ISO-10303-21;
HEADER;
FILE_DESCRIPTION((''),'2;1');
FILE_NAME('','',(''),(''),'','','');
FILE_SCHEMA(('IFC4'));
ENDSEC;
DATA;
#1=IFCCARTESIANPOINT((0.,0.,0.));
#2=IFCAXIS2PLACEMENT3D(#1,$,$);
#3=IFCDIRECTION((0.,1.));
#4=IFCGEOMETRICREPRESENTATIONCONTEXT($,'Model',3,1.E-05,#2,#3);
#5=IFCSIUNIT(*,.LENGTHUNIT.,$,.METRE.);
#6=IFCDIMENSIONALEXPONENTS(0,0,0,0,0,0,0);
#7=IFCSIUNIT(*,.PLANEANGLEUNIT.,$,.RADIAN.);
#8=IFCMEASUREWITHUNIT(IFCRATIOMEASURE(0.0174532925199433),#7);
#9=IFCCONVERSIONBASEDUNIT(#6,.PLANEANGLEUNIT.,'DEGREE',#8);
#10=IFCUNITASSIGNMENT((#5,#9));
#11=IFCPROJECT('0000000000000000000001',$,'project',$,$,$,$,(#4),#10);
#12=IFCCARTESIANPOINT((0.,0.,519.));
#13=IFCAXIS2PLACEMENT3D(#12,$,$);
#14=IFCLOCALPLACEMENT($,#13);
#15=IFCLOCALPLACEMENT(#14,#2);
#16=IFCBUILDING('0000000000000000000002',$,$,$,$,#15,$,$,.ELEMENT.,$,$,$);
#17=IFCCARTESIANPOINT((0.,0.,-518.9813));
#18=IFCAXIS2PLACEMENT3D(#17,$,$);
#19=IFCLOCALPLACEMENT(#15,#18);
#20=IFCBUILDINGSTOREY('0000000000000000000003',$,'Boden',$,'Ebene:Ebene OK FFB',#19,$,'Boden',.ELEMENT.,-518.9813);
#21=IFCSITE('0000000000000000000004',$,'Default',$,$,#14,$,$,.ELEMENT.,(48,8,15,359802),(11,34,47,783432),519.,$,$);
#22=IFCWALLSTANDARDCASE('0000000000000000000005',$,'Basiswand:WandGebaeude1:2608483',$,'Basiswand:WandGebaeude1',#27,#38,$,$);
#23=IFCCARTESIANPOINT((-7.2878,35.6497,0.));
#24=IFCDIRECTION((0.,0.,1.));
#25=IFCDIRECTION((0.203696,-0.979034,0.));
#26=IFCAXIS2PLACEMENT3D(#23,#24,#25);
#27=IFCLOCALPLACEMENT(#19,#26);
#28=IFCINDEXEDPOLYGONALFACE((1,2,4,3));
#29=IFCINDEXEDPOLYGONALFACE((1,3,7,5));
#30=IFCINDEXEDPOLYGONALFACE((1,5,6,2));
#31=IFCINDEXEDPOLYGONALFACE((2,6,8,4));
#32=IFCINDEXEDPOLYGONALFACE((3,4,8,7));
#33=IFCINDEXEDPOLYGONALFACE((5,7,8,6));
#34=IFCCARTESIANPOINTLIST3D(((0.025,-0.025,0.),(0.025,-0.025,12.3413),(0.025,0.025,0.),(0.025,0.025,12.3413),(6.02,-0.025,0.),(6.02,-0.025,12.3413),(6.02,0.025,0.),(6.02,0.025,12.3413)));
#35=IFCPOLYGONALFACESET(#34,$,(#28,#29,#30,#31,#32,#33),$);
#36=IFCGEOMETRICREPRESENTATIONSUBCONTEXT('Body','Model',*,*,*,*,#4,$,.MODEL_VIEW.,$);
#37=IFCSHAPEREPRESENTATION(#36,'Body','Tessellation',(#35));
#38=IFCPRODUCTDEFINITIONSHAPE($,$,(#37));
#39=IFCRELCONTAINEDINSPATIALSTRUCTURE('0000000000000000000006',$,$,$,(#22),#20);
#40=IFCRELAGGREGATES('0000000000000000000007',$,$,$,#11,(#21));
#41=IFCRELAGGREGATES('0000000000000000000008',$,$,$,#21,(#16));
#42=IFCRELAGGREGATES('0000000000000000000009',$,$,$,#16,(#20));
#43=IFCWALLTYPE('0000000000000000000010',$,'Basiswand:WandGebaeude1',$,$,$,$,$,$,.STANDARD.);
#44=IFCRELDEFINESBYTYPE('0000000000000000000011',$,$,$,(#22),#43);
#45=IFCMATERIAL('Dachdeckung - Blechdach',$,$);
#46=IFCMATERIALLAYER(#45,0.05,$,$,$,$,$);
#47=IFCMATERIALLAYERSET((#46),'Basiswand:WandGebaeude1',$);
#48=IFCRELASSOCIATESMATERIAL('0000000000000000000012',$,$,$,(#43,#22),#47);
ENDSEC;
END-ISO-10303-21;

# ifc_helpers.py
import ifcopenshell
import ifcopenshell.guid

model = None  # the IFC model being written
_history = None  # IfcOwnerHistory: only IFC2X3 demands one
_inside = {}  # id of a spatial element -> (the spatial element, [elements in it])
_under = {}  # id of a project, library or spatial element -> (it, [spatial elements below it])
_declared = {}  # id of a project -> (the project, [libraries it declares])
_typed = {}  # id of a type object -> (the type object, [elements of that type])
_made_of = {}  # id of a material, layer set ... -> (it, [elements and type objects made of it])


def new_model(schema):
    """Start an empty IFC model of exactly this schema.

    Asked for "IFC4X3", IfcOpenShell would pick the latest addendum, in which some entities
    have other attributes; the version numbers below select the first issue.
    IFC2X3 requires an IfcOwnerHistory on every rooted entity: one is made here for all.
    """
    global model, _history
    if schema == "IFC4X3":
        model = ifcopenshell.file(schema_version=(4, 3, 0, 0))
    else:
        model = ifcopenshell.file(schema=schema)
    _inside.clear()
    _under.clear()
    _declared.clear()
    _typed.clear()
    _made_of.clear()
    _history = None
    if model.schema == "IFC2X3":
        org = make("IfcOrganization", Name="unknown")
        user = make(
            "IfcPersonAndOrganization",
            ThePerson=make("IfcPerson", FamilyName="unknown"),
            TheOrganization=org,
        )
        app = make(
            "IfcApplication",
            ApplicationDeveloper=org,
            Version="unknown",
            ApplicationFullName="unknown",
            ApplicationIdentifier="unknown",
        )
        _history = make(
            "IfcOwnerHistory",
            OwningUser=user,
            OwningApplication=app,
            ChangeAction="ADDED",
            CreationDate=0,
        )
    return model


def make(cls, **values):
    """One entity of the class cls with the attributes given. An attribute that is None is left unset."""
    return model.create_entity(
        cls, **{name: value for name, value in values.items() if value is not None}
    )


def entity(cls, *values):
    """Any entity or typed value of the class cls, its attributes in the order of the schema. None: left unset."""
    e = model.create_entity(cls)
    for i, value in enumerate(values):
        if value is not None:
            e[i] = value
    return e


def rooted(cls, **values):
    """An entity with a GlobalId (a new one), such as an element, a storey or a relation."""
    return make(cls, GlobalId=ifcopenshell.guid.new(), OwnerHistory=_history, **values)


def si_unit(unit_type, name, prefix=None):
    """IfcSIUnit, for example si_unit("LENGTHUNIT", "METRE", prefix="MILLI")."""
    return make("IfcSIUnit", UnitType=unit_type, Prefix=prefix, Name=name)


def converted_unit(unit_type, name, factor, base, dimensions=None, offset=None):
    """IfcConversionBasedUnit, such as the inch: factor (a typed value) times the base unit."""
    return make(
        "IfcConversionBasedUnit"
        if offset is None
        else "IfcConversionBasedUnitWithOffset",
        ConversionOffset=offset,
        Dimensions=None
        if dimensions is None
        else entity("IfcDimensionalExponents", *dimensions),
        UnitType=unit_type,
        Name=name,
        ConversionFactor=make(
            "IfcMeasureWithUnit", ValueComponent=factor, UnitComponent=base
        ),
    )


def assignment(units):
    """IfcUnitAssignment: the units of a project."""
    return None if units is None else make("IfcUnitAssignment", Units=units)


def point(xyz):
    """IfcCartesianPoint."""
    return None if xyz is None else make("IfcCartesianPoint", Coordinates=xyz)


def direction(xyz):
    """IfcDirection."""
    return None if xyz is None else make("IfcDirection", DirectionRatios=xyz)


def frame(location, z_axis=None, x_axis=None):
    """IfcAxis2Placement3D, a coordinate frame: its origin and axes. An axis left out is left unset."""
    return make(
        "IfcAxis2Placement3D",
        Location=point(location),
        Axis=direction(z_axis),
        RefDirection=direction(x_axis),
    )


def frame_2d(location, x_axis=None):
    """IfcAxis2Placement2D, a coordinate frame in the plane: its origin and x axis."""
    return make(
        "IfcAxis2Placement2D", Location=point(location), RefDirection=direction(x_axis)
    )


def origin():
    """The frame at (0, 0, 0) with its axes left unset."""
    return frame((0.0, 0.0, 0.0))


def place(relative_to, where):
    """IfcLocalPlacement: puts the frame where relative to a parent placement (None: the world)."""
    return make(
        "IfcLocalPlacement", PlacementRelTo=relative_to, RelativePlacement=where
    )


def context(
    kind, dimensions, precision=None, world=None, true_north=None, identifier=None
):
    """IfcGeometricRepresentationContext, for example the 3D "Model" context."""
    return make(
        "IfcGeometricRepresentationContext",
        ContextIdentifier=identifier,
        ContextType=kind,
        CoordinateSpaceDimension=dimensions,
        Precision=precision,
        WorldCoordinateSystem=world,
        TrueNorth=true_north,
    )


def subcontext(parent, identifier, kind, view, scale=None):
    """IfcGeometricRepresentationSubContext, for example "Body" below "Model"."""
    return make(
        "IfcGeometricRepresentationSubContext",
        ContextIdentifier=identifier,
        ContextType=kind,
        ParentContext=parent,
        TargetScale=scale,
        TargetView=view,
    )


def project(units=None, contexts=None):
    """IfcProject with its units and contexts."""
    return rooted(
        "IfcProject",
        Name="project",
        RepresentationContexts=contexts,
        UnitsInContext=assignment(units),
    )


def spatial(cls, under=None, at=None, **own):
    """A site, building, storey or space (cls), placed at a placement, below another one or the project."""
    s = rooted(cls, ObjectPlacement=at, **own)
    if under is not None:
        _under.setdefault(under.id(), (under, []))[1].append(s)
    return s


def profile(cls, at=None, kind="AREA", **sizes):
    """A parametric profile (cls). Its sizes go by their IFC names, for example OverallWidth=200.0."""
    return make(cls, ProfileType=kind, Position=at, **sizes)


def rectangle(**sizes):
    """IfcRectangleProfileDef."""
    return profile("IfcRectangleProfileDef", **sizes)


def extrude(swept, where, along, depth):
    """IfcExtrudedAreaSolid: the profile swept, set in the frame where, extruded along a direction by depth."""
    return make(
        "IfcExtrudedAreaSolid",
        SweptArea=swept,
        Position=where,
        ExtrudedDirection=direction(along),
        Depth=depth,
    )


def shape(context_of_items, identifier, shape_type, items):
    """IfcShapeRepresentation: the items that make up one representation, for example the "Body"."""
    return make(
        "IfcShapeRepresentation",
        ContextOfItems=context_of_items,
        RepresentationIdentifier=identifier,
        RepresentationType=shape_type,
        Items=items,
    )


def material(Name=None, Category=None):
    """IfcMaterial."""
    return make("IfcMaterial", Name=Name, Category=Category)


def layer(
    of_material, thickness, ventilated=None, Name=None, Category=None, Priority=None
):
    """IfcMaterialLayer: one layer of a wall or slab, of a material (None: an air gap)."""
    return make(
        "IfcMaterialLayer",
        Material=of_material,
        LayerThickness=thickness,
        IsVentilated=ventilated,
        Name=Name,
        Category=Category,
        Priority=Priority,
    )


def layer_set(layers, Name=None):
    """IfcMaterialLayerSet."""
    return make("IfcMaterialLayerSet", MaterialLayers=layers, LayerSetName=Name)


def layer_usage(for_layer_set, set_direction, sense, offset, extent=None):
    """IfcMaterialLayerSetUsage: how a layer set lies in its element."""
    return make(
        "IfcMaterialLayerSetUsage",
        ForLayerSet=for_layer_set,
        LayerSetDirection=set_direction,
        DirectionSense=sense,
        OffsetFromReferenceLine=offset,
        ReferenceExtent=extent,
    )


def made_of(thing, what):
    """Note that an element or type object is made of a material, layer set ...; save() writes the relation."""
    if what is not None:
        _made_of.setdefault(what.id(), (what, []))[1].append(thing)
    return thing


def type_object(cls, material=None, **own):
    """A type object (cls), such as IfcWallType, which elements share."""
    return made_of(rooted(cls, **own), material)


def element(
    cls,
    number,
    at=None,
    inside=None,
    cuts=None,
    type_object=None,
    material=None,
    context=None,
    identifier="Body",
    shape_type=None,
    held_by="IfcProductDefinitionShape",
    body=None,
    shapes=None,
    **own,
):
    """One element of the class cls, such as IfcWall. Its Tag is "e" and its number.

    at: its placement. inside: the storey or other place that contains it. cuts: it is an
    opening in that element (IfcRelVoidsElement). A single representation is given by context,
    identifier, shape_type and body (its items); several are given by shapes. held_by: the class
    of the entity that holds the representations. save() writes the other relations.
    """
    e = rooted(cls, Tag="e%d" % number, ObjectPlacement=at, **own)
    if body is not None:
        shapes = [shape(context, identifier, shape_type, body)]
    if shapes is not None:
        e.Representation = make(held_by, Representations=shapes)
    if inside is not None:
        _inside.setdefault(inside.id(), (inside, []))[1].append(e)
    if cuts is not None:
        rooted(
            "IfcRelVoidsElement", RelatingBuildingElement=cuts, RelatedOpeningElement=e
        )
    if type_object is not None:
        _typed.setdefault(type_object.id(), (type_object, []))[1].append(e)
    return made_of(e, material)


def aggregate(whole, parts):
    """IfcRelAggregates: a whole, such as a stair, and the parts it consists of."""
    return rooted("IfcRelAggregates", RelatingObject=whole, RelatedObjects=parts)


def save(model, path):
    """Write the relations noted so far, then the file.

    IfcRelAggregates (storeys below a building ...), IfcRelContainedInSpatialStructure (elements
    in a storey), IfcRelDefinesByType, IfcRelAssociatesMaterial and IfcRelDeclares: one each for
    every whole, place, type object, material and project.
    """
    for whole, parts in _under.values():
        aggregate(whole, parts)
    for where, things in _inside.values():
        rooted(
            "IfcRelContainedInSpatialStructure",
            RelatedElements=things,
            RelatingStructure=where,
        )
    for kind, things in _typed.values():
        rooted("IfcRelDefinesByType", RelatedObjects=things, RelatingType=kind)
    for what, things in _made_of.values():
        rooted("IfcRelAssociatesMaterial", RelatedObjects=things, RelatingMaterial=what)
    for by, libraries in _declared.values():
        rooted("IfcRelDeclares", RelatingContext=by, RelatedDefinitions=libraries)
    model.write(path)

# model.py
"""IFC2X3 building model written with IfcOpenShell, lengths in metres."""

from ifc_helpers import new_model, entity, si_unit, converted_unit, direction, frame, frame_2d, origin, place, context, subcontext, project, spatial, rectangle, extrude, material, layer, layer_set, layer_usage, type_object, element, save


model = new_model("IFC2X3")

# Units and contexts
model_context = context("Model", 3, precision=1e-05, world=origin(), true_north=direction((0.0, 1.0)))
body_context = subcontext(model_context, "Body", "Model", "MODEL_VIEW")
ifc_project = project(units=[si_unit("LENGTHUNIT", "METRE"), converted_unit("PLANEANGLEUNIT", "DEGREE", entity("IfcRatioMeasure", 0.0174532925199433), si_unit("PLANEANGLEUNIT", "RADIAN"), dimensions=[0, 0, 0, 0, 0, 0, 0])], contexts=[model_context])

# Site, building, storey
site_placement = place(None, frame((0.0, 0.0, 519.0)))
site = spatial("IfcSite", under=ifc_project, at=site_placement, Name="Default", CompositionType="ELEMENT", RefLatitude=(48, 8, 15, 359802), RefLongitude=(11, 34, 47, 783432), RefElevation=519.0)
building_placement = place(site_placement, origin())
building = spatial("IfcBuilding", under=site, at=building_placement, CompositionType="ELEMENT")
storey_placement = place(building_placement, frame((0.0, 0.0, -518.9813)))
storey = spatial("IfcBuildingStorey", under=building, at=storey_placement, Name="Boden", ObjectType="Ebene:Ebene OK FFB", LongName="Boden", CompositionType="ELEMENT", Elevation=-518.9813)

# Wall
ifc_material_1 = material(Name="Dachdeckung - Blechdach")
ifc_layer_1 = layer(ifc_material_1, 0.05)
ifc_layer_set_1 = layer_set([ifc_layer_1], Name="Basiswand:WandGebaeude1")
ifc_layer_usage_1 = layer_usage(ifc_layer_set_1, "AXIS2", "NEGATIVE", 0.025)
wall_type_1 = type_object("IfcWallType", Name="Basiswand:WandGebaeude1", PredefinedType="STANDARD", material=ifc_layer_set_1)
wall_1_placement = place(storey_placement, frame((-7.2878, 35.6497, 0.0), z_axis=(0.0, 0.0, 1.0), x_axis=(0.203696, -0.979034, 0.0)))
element("IfcWallStandardCase", 1, at=wall_1_placement, inside=storey, type_object=wall_type_1, material=ifc_layer_usage_1, Name="Basiswand:WandGebaeude1:2608483", ObjectType="Basiswand:WandGebaeude1", context=body_context, shape_type="SweptSolid", body=[
    extrude(rectangle(XDim=5.995, YDim=0.05, at=frame_2d((3.0225, 0.0), x_axis=(-1.0, 0.0))), origin(), (0.0, 0.0, 1.0), 12.3413),
])

save(model, "model.ifc")
